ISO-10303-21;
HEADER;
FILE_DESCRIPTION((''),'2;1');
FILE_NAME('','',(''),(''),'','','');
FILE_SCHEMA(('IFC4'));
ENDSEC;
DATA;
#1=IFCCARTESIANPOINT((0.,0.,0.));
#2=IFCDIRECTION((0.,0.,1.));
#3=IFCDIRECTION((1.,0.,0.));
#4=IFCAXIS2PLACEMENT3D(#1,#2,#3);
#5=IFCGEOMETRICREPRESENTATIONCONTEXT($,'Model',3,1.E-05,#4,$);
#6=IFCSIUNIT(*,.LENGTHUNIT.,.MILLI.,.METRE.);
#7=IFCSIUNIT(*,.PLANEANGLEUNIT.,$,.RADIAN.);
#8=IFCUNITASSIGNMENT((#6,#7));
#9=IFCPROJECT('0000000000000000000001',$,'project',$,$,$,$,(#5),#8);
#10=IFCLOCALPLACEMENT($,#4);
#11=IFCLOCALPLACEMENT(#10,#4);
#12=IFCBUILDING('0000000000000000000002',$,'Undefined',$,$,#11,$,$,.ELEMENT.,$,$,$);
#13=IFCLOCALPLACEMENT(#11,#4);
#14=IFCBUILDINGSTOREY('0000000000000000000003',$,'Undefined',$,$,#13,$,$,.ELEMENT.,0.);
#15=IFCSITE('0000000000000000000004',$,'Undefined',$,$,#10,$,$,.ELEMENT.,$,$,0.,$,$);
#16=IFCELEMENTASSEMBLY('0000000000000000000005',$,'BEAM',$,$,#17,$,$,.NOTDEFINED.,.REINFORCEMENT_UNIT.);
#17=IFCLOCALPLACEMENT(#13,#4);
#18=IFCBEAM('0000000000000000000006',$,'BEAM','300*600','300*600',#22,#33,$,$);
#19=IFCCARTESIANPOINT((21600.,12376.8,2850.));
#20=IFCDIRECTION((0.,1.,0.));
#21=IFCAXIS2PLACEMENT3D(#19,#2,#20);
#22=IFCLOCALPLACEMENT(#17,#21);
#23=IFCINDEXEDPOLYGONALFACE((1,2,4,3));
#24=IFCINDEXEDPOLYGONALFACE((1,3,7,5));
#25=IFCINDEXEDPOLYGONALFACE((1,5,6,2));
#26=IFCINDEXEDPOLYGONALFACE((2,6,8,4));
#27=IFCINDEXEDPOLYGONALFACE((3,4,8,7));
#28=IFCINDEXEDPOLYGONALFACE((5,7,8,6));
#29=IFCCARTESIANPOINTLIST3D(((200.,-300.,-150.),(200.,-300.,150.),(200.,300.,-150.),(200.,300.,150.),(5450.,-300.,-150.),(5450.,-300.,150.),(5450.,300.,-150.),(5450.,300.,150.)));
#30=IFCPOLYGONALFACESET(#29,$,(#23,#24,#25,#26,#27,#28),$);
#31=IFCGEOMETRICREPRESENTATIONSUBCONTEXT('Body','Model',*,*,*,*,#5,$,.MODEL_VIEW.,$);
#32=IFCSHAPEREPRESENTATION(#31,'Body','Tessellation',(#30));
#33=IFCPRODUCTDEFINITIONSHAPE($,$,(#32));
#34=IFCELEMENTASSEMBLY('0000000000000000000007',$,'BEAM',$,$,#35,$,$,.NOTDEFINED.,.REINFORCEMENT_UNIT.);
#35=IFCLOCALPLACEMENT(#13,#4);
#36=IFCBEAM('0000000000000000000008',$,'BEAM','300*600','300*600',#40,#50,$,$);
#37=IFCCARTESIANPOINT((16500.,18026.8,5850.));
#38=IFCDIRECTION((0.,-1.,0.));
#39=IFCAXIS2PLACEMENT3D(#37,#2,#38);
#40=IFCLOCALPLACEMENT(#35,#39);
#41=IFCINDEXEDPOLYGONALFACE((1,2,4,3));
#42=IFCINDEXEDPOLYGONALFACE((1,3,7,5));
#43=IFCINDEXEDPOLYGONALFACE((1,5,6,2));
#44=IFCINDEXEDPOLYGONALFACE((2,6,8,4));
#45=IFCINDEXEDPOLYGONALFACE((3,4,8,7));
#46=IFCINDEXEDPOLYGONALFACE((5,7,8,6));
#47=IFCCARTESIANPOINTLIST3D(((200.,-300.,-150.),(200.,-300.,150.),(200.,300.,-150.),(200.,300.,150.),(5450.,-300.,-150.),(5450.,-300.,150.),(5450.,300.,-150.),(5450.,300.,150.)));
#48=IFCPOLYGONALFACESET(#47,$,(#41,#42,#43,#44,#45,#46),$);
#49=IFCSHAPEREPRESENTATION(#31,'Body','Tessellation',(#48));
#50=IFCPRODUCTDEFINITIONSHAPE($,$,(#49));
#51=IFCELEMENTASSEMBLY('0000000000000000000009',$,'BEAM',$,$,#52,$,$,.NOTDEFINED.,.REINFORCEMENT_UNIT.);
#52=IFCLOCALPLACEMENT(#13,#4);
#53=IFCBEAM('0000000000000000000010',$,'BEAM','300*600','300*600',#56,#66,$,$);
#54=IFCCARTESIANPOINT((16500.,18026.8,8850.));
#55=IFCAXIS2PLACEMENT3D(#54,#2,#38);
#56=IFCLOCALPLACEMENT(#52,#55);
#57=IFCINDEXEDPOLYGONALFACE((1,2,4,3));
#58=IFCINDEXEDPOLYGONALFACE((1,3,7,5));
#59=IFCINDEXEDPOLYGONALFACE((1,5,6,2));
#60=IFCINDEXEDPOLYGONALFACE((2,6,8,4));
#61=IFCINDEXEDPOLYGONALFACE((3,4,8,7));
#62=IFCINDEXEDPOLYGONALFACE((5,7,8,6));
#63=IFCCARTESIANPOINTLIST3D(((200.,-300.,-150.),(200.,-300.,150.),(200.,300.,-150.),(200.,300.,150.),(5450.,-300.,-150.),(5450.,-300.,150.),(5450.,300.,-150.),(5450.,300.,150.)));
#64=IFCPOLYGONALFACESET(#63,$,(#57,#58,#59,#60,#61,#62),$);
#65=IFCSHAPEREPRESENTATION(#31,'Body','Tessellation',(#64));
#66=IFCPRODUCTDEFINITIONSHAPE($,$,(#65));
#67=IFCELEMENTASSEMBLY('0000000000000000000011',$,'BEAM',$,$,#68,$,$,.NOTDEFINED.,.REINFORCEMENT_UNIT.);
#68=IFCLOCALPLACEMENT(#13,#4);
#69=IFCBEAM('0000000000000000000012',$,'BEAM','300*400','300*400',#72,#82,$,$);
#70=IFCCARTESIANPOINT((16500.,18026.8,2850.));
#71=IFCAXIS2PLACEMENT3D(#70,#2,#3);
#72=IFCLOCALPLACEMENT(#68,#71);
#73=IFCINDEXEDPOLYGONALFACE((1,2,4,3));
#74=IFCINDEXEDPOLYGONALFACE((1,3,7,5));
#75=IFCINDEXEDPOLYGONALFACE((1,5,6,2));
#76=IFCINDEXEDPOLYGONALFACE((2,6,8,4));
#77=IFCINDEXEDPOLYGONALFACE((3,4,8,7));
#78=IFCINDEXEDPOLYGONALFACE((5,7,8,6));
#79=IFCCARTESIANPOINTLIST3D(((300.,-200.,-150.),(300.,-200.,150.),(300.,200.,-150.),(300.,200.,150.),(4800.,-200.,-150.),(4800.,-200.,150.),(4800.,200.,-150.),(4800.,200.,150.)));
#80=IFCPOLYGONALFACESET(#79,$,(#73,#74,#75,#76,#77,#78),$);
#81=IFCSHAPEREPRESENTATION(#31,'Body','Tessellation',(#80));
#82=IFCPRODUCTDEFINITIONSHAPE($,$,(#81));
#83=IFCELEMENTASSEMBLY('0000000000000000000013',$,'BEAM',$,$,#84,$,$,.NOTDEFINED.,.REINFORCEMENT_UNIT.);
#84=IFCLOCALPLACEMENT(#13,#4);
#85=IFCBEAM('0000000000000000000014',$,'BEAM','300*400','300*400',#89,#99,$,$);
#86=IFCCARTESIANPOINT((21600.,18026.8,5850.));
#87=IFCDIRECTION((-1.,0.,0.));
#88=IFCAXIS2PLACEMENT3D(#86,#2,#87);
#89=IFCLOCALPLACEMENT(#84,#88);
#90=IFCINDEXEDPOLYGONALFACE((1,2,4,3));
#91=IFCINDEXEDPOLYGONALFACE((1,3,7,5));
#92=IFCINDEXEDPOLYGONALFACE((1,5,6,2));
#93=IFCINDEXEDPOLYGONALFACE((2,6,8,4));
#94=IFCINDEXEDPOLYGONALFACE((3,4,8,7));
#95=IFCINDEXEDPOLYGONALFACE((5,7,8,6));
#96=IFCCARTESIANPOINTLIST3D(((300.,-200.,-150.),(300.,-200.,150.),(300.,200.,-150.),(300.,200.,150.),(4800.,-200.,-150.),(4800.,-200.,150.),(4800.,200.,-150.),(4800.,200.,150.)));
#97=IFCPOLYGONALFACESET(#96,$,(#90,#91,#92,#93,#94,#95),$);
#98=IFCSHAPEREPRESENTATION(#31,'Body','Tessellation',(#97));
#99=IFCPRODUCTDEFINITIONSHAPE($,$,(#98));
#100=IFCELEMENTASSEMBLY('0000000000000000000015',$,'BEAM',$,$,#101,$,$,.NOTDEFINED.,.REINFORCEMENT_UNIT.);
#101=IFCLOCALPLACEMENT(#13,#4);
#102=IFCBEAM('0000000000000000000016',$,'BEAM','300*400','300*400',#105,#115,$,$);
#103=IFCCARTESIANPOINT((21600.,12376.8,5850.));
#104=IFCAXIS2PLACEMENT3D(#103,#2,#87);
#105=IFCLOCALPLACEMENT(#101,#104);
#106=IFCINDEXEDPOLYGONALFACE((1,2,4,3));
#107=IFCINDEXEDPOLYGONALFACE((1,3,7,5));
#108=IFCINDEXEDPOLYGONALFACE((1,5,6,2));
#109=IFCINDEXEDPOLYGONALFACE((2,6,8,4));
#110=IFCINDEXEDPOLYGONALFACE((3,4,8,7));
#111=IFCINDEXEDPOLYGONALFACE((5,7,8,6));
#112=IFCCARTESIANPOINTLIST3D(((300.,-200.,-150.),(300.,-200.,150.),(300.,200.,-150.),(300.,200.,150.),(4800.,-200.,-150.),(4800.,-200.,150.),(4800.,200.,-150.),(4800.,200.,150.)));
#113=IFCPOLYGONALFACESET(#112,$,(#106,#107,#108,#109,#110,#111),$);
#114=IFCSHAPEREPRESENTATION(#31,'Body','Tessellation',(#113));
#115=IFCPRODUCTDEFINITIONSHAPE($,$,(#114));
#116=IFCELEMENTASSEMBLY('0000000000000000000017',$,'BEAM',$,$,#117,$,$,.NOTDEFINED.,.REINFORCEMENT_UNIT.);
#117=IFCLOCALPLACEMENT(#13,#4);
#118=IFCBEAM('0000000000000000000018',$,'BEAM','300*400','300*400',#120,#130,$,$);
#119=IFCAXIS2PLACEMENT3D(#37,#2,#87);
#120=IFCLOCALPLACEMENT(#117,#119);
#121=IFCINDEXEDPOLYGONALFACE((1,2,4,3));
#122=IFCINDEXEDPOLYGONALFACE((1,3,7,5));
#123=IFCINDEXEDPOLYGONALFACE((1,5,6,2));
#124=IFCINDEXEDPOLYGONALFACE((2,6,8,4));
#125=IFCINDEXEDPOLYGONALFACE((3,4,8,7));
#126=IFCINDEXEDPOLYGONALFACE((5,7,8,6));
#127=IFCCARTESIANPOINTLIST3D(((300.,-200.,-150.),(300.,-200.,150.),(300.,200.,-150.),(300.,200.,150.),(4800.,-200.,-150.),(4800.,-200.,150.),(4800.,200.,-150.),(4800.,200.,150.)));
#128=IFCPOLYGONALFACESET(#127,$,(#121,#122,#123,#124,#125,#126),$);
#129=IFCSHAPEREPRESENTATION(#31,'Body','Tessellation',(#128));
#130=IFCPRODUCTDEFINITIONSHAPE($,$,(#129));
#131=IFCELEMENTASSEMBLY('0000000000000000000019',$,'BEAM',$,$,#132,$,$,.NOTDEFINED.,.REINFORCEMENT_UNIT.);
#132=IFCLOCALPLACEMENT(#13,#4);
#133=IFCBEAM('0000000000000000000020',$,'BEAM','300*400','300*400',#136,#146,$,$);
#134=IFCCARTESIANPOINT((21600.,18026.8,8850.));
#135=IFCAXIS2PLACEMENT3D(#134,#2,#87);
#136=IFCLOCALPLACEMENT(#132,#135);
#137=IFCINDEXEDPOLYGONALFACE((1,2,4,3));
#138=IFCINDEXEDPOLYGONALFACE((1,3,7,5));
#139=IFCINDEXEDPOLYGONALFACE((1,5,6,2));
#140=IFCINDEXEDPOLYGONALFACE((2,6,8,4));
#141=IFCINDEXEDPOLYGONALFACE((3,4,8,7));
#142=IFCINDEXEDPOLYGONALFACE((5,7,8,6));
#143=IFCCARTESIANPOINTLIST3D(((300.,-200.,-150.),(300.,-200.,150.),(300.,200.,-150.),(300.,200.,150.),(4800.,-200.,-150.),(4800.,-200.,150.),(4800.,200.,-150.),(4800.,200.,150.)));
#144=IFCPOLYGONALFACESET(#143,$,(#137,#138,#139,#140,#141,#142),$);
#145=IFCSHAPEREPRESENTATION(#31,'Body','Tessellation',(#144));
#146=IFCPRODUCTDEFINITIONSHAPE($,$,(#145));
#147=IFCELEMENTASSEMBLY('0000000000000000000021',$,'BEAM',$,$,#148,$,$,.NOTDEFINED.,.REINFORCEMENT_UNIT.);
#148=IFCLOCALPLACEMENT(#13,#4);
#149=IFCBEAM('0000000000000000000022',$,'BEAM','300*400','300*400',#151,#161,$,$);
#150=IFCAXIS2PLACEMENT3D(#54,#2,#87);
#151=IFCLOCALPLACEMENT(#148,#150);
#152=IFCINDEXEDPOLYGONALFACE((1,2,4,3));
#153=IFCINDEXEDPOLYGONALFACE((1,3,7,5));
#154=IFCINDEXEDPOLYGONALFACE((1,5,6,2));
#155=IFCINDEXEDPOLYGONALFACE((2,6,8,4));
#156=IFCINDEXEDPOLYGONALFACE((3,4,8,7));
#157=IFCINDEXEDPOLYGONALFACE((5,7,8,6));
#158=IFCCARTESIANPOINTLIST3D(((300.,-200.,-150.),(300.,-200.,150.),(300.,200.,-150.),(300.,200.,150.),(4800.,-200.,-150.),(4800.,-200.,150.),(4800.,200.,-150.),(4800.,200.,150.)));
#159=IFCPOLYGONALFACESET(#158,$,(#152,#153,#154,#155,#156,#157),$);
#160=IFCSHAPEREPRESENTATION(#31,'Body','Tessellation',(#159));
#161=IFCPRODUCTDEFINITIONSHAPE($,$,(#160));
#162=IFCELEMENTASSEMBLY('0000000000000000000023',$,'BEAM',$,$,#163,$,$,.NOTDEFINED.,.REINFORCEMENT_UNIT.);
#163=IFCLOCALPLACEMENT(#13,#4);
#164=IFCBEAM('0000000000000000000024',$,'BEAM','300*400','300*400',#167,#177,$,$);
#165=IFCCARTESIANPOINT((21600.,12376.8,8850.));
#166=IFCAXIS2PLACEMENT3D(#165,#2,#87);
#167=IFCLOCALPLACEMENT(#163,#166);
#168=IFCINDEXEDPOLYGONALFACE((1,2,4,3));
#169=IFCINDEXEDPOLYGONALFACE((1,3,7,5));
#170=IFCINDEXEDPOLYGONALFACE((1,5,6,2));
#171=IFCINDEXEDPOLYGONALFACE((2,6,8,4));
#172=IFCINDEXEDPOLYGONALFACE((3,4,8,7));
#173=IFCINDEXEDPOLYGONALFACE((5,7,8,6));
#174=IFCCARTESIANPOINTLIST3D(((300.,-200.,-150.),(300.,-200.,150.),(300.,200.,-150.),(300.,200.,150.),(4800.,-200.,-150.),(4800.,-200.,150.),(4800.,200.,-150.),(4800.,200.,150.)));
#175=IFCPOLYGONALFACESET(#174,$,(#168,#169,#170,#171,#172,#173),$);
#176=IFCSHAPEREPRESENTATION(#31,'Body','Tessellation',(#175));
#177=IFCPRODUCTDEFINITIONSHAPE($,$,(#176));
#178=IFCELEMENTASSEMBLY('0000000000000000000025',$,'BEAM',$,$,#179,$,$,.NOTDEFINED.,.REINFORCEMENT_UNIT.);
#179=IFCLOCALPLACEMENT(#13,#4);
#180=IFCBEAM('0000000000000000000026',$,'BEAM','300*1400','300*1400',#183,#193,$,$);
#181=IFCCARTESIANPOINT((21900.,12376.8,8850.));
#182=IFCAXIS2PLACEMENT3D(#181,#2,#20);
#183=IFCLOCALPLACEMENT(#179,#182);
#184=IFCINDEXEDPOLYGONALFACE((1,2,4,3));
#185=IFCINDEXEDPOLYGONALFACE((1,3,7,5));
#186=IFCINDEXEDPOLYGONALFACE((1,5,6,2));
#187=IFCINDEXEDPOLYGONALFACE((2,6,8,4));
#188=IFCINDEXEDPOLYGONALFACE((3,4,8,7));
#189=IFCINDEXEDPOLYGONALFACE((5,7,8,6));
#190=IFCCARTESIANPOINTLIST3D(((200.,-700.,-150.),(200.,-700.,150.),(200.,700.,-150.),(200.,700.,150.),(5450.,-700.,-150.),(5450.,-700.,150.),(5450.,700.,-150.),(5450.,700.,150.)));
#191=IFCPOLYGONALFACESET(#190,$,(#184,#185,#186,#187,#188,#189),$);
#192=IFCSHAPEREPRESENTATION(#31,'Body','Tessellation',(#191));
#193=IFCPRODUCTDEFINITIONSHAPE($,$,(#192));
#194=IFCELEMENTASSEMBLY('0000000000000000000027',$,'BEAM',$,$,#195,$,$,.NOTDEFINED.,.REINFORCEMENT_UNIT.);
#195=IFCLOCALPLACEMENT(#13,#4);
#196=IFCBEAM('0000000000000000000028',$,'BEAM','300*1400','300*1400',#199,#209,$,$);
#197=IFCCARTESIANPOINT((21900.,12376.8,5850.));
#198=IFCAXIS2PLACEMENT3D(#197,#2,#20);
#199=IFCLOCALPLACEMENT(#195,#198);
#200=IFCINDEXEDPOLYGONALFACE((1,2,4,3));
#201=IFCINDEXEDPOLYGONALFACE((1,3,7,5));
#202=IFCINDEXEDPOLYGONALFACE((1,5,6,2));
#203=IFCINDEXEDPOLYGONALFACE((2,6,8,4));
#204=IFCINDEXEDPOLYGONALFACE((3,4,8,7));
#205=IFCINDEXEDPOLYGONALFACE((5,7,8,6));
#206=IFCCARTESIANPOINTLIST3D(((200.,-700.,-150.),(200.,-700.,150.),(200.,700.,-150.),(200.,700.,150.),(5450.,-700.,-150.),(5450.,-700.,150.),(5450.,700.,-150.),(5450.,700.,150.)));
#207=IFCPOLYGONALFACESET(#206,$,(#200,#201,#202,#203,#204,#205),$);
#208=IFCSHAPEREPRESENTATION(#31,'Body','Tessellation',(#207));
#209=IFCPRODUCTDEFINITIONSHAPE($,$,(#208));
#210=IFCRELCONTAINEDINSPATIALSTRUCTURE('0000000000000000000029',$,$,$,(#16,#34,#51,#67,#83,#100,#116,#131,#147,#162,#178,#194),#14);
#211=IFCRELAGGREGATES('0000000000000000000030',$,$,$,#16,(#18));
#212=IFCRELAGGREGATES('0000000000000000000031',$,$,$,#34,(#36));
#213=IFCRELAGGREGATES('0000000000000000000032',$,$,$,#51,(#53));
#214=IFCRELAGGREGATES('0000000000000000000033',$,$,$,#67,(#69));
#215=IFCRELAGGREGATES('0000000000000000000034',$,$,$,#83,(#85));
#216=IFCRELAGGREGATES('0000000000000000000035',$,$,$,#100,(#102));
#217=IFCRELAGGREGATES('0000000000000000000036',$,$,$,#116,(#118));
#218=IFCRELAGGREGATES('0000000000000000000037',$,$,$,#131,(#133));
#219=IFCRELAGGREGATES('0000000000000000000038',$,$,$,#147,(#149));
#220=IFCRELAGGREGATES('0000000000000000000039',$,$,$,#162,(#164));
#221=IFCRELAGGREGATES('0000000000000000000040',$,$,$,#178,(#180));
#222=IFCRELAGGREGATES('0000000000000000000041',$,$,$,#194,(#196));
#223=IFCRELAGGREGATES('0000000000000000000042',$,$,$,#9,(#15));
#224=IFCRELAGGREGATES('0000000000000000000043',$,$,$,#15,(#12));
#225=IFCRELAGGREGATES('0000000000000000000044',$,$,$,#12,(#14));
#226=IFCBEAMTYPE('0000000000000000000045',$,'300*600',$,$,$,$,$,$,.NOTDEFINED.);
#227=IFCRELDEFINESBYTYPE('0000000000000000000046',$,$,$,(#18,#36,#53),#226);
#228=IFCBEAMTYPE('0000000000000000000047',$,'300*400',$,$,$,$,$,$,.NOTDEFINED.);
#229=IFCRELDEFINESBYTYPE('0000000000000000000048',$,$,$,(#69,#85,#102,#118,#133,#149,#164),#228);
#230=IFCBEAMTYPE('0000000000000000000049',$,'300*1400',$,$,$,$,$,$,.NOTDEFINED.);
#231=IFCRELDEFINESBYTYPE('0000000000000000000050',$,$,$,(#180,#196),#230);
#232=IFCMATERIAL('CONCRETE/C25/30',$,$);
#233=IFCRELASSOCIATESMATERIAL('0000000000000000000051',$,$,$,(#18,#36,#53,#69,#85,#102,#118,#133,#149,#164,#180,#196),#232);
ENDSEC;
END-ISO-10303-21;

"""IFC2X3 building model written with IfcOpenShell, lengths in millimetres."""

from ifc_helpers import new_model, si_unit, frame, origin_with_axes, origin_2d_with_axis, place, context, subcontext, project, spatial, rectangle, extrude, material, type_object, element, aggregate, save


model = new_model("IFC2X3")

# Units and contexts
model_context = context("Model", 3, precision=1e-05, world=origin_with_axes())
body_context = subcontext(model_context, "Body", "Model", "MODEL_VIEW")
ifc_project = project(units=[si_unit("LENGTHUNIT", "METRE", prefix="MILLI"), si_unit("PLANEANGLEUNIT", "RADIAN")], contexts=[model_context])

# Site, building, storey
site_placement = place(None, origin_with_axes())
site = spatial("IfcSite", under=ifc_project, at=site_placement, Name="Undefined", CompositionType="ELEMENT", RefElevation=0.0)
building_placement = place(site_placement, origin_with_axes())
building = spatial("IfcBuilding", under=site, at=building_placement, Name="Undefined", CompositionType="ELEMENT")
storey_placement = place(building_placement, origin_with_axes())
storey = spatial("IfcBuildingStorey", under=building, at=storey_placement, Name="Undefined", CompositionType="ELEMENT", Elevation=0.0)

# Shared definitions
ifc_material = material(Name="CONCRETE/C25/30")

# Element assemblies, beams
assembly_1_placement = place(storey_placement, origin_with_axes())
assembly_1 = element("IfcElementAssembly", 1, at=assembly_1_placement, inside=storey, Name="BEAM", AssemblyPlace="NOTDEFINED", PredefinedType="REINFORCEMENT_UNIT")
beam_type_1 = type_object("IfcBeamType", Name="300*600", PredefinedType="NOTDEFINED")
beam_1_placement = place(assembly_1_placement, frame((21600.0, 12376.8, 2850.0), z_axis=(0.0, 0.0, 1.0), x_axis=(0.0, 1.0, 0.0)))
beam_1 = element("IfcBeam", 2, at=beam_1_placement, type_object=beam_type_1, material=ifc_material, Name="BEAM", Description="300*600", ObjectType="300*600", context=body_context, shape_type="SweptSolid", body=[
    extrude(rectangle(XDim=600.0, YDim=300.0, at=origin_2d_with_axis()), frame((5450.0, 0.0, 0.0), z_axis=(-1.0, 0.0, 0.0), x_axis=(0.0, -1.0, 0.0)), (0.0, 0.0, 1.0), 5250.0),
])
aggregate(assembly_1, [beam_1])
assembly_2_placement = place(storey_placement, origin_with_axes())
assembly_2 = element("IfcElementAssembly", 3, at=assembly_2_placement, inside=storey, Name="BEAM", AssemblyPlace="NOTDEFINED", PredefinedType="REINFORCEMENT_UNIT")
beam_2_placement = place(assembly_2_placement, frame((16500.0, 18026.8, 5850.0), z_axis=(0.0, 0.0, 1.0), x_axis=(0.0, -1.0, 0.0)))
beam_2 = element("IfcBeam", 4, at=beam_2_placement, type_object=beam_type_1, material=ifc_material, Name="BEAM", Description="300*600", ObjectType="300*600", context=body_context, shape_type="SweptSolid", body=[
    extrude(rectangle(XDim=600.0, YDim=300.0, at=origin_2d_with_axis()), frame((5450.0, 0.0, 0.0), z_axis=(-1.0, 0.0, 0.0), x_axis=(0.0, -1.0, 0.0)), (0.0, 0.0, 1.0), 5250.0),
])
aggregate(assembly_2, [beam_2])
assembly_3_placement = place(storey_placement, origin_with_axes())
assembly_3 = element("IfcElementAssembly", 5, at=assembly_3_placement, inside=storey, Name="BEAM", AssemblyPlace="NOTDEFINED", PredefinedType="REINFORCEMENT_UNIT")
beam_3_placement = place(assembly_3_placement, frame((16500.0, 18026.8, 8850.0), z_axis=(0.0, 0.0, 1.0), x_axis=(0.0, -1.0, 0.0)))
beam_3 = element("IfcBeam", 6, at=beam_3_placement, type_object=beam_type_1, material=ifc_material, Name="BEAM", Description="300*600", ObjectType="300*600", context=body_context, shape_type="SweptSolid", body=[
    extrude(rectangle(XDim=600.0, YDim=300.0, at=origin_2d_with_axis()), frame((5450.0, 0.0, 0.0), z_axis=(-1.0, 0.0, 0.0), x_axis=(0.0, -1.0, 0.0)), (0.0, 0.0, 1.0), 5250.0),
])
aggregate(assembly_3, [beam_3])
assembly_4_placement = place(storey_placement, origin_with_axes())
assembly_4 = element("IfcElementAssembly", 7, at=assembly_4_placement, inside=storey, Name="BEAM", AssemblyPlace="NOTDEFINED", PredefinedType="REINFORCEMENT_UNIT")
beam_type_2 = type_object("IfcBeamType", Name="300*400", PredefinedType="NOTDEFINED")
beam_4_placement = place(assembly_4_placement, frame((16500.0, 18026.8, 2850.0), z_axis=(0.0, 0.0, 1.0), x_axis=(1.0, 0.0, 0.0)))
beam_4 = element("IfcBeam", 8, at=beam_4_placement, type_object=beam_type_2, material=ifc_material, Name="BEAM", Description="300*400", ObjectType="300*400", context=body_context, shape_type="SweptSolid", body=[
    extrude(rectangle(XDim=400.0, YDim=300.0, at=origin_2d_with_axis()), frame((4800.0, 0.0, 0.0), z_axis=(-1.0, 0.0, 0.0), x_axis=(0.0, -1.0, 0.0)), (0.0, 0.0, 1.0), 4500.0),
])
aggregate(assembly_4, [beam_4])
assembly_5_placement = place(storey_placement, origin_with_axes())
assembly_5 = element("IfcElementAssembly", 9, at=assembly_5_placement, inside=storey, Name="BEAM", AssemblyPlace="NOTDEFINED", PredefinedType="REINFORCEMENT_UNIT")
beam_5_placement = place(assembly_5_placement, frame((21600.0, 18026.8, 5850.0), z_axis=(0.0, 0.0, 1.0), x_axis=(-1.0, 0.0, 0.0)))
beam_5 = element("IfcBeam", 10, at=beam_5_placement, type_object=beam_type_2, material=ifc_material, Name="BEAM", Description="300*400", ObjectType="300*400", context=body_context, shape_type="SweptSolid", body=[
    extrude(rectangle(XDim=400.0, YDim=300.0, at=origin_2d_with_axis()), frame((4800.0, 0.0, 0.0), z_axis=(-1.0, 0.0, 0.0), x_axis=(0.0, -1.0, 0.0)), (0.0, 0.0, 1.0), 4500.0),
])
aggregate(assembly_5, [beam_5])
assembly_6_placement = place(storey_placement, origin_with_axes())
assembly_6 = element("IfcElementAssembly", 11, at=assembly_6_placement, inside=storey, Name="BEAM", AssemblyPlace="NOTDEFINED", PredefinedType="REINFORCEMENT_UNIT")
beam_6_placement = place(assembly_6_placement, frame((21600.0, 12376.8, 5850.0), z_axis=(0.0, 0.0, 1.0), x_axis=(-1.0, 0.0, 0.0)))
beam_6 = element("IfcBeam", 12, at=beam_6_placement, type_object=beam_type_2, material=ifc_material, Name="BEAM", Description="300*400", ObjectType="300*400", context=body_context, shape_type="SweptSolid", body=[
    extrude(rectangle(XDim=400.0, YDim=300.0, at=origin_2d_with_axis()), frame((4800.0, 0.0, 0.0), z_axis=(-1.0, 0.0, 0.0), x_axis=(0.0, -1.0, 0.0)), (0.0, 0.0, 1.0), 4500.0),
])
aggregate(assembly_6, [beam_6])
assembly_7_placement = place(storey_placement, origin_with_axes())
assembly_7 = element("IfcElementAssembly", 13, at=assembly_7_placement, inside=storey, Name="BEAM", AssemblyPlace="NOTDEFINED", PredefinedType="REINFORCEMENT_UNIT")
beam_7_placement = place(assembly_7_placement, frame((16500.0, 18026.8, 5850.0), z_axis=(0.0, 0.0, 1.0), x_axis=(-1.0, 0.0, 0.0)))
beam_7 = element("IfcBeam", 14, at=beam_7_placement, type_object=beam_type_2, material=ifc_material, Name="BEAM", Description="300*400", ObjectType="300*400", context=body_context, shape_type="SweptSolid", body=[
    extrude(rectangle(XDim=400.0, YDim=300.0, at=origin_2d_with_axis()), frame((4800.0, 0.0, 0.0), z_axis=(-1.0, 0.0, 0.0), x_axis=(0.0, -1.0, 0.0)), (0.0, 0.0, 1.0), 4500.0),
])
aggregate(assembly_7, [beam_7])
assembly_8_placement = place(storey_placement, origin_with_axes())
assembly_8 = element("IfcElementAssembly", 15, at=assembly_8_placement, inside=storey, Name="BEAM", AssemblyPlace="NOTDEFINED", PredefinedType="REINFORCEMENT_UNIT")
beam_8_placement = place(assembly_8_placement, frame((21600.0, 18026.8, 8850.0), z_axis=(0.0, 0.0, 1.0), x_axis=(-1.0, 0.0, 0.0)))
beam_8 = element("IfcBeam", 16, at=beam_8_placement, type_object=beam_type_2, material=ifc_material, Name="BEAM", Description="300*400", ObjectType="300*400", context=body_context, shape_type="SweptSolid", body=[
    extrude(rectangle(XDim=400.0, YDim=300.0, at=origin_2d_with_axis()), frame((4800.0, 0.0, 0.0), z_axis=(-1.0, 0.0, 0.0), x_axis=(0.0, -1.0, 0.0)), (0.0, 0.0, 1.0), 4500.0),
])
aggregate(assembly_8, [beam_8])
assembly_9_placement = place(storey_placement, origin_with_axes())
assembly_9 = element("IfcElementAssembly", 17, at=assembly_9_placement, inside=storey, Name="BEAM", AssemblyPlace="NOTDEFINED", PredefinedType="REINFORCEMENT_UNIT")
beam_9_placement = place(assembly_9_placement, frame((16500.0, 18026.8, 8850.0), z_axis=(0.0, 0.0, 1.0), x_axis=(-1.0, 0.0, 0.0)))
beam_9 = element("IfcBeam", 18, at=beam_9_placement, type_object=beam_type_2, material=ifc_material, Name="BEAM", Description="300*400", ObjectType="300*400", context=body_context, shape_type="SweptSolid", body=[
    extrude(rectangle(XDim=400.0, YDim=300.0, at=origin_2d_with_axis()), frame((4800.0, 0.0, 0.0), z_axis=(-1.0, 0.0, 0.0), x_axis=(0.0, -1.0, 0.0)), (0.0, 0.0, 1.0), 4500.0),
])
aggregate(assembly_9, [beam_9])
assembly_10_placement = place(storey_placement, origin_with_axes())
assembly_10 = element("IfcElementAssembly", 19, at=assembly_10_placement, inside=storey, Name="BEAM", AssemblyPlace="NOTDEFINED", PredefinedType="REINFORCEMENT_UNIT")
beam_10_placement = place(assembly_10_placement, frame((21600.0, 12376.8, 8850.0), z_axis=(0.0, 0.0, 1.0), x_axis=(-1.0, 0.0, 0.0)))
beam_10 = element("IfcBeam", 20, at=beam_10_placement, type_object=beam_type_2, material=ifc_material, Name="BEAM", Description="300*400", ObjectType="300*400", context=body_context, shape_type="SweptSolid", body=[
    extrude(rectangle(XDim=400.0, YDim=300.0, at=origin_2d_with_axis()), frame((4800.0, 0.0, 0.0), z_axis=(-1.0, 0.0, 0.0), x_axis=(0.0, -1.0, 0.0)), (0.0, 0.0, 1.0), 4500.0),
])
aggregate(assembly_10, [beam_10])
beam_type_3 = type_object("IfcBeamType", Name="300*1400", PredefinedType="NOTDEFINED")
assembly_11_placement = place(storey_placement, origin_with_axes())
assembly_11 = element("IfcElementAssembly", 21, at=assembly_11_placement, inside=storey, Name="BEAM", AssemblyPlace="NOTDEFINED", PredefinedType="REINFORCEMENT_UNIT")
beam_11_placement = place(assembly_11_placement, frame((21900.0, 12376.8, 8850.0), z_axis=(0.0, 0.0, 1.0), x_axis=(0.0, 1.0, 0.0)))
beam_11 = element("IfcBeam", 22, at=beam_11_placement, type_object=beam_type_3, material=ifc_material, Name="BEAM", Description="300*1400", ObjectType="300*1400", context=body_context, shape_type="SweptSolid", body=[
    extrude(rectangle(XDim=1400.0, YDim=300.0, at=origin_2d_with_axis()), frame((5450.0, 0.0, 0.0), z_axis=(-1.0, 0.0, 0.0), x_axis=(0.0, -1.0, 0.0)), (0.0, 0.0, 1.0), 5250.0),
])
aggregate(assembly_11, [beam_11])
assembly_12_placement = place(storey_placement, origin_with_axes())
assembly_12 = element("IfcElementAssembly", 23, at=assembly_12_placement, inside=storey, Name="BEAM", AssemblyPlace="NOTDEFINED", PredefinedType="REINFORCEMENT_UNIT")
beam_12_placement = place(assembly_12_placement, frame((21900.0, 12376.8, 5850.0), z_axis=(0.0, 0.0, 1.0), x_axis=(0.0, 1.0, 0.0)))
beam_12 = element("IfcBeam", 24, at=beam_12_placement, type_object=beam_type_3, material=ifc_material, Name="BEAM", Description="300*1400", ObjectType="300*1400", context=body_context, shape_type="SweptSolid", body=[
    extrude(rectangle(XDim=1400.0, YDim=300.0, at=origin_2d_with_axis()), frame((5450.0, 0.0, 0.0), z_axis=(-1.0, 0.0, 0.0), x_axis=(0.0, -1.0, 0.0)), (0.0, 0.0, 1.0), 5250.0),
])
aggregate(assembly_12, [beam_12])

save(model, "model.ifc")
